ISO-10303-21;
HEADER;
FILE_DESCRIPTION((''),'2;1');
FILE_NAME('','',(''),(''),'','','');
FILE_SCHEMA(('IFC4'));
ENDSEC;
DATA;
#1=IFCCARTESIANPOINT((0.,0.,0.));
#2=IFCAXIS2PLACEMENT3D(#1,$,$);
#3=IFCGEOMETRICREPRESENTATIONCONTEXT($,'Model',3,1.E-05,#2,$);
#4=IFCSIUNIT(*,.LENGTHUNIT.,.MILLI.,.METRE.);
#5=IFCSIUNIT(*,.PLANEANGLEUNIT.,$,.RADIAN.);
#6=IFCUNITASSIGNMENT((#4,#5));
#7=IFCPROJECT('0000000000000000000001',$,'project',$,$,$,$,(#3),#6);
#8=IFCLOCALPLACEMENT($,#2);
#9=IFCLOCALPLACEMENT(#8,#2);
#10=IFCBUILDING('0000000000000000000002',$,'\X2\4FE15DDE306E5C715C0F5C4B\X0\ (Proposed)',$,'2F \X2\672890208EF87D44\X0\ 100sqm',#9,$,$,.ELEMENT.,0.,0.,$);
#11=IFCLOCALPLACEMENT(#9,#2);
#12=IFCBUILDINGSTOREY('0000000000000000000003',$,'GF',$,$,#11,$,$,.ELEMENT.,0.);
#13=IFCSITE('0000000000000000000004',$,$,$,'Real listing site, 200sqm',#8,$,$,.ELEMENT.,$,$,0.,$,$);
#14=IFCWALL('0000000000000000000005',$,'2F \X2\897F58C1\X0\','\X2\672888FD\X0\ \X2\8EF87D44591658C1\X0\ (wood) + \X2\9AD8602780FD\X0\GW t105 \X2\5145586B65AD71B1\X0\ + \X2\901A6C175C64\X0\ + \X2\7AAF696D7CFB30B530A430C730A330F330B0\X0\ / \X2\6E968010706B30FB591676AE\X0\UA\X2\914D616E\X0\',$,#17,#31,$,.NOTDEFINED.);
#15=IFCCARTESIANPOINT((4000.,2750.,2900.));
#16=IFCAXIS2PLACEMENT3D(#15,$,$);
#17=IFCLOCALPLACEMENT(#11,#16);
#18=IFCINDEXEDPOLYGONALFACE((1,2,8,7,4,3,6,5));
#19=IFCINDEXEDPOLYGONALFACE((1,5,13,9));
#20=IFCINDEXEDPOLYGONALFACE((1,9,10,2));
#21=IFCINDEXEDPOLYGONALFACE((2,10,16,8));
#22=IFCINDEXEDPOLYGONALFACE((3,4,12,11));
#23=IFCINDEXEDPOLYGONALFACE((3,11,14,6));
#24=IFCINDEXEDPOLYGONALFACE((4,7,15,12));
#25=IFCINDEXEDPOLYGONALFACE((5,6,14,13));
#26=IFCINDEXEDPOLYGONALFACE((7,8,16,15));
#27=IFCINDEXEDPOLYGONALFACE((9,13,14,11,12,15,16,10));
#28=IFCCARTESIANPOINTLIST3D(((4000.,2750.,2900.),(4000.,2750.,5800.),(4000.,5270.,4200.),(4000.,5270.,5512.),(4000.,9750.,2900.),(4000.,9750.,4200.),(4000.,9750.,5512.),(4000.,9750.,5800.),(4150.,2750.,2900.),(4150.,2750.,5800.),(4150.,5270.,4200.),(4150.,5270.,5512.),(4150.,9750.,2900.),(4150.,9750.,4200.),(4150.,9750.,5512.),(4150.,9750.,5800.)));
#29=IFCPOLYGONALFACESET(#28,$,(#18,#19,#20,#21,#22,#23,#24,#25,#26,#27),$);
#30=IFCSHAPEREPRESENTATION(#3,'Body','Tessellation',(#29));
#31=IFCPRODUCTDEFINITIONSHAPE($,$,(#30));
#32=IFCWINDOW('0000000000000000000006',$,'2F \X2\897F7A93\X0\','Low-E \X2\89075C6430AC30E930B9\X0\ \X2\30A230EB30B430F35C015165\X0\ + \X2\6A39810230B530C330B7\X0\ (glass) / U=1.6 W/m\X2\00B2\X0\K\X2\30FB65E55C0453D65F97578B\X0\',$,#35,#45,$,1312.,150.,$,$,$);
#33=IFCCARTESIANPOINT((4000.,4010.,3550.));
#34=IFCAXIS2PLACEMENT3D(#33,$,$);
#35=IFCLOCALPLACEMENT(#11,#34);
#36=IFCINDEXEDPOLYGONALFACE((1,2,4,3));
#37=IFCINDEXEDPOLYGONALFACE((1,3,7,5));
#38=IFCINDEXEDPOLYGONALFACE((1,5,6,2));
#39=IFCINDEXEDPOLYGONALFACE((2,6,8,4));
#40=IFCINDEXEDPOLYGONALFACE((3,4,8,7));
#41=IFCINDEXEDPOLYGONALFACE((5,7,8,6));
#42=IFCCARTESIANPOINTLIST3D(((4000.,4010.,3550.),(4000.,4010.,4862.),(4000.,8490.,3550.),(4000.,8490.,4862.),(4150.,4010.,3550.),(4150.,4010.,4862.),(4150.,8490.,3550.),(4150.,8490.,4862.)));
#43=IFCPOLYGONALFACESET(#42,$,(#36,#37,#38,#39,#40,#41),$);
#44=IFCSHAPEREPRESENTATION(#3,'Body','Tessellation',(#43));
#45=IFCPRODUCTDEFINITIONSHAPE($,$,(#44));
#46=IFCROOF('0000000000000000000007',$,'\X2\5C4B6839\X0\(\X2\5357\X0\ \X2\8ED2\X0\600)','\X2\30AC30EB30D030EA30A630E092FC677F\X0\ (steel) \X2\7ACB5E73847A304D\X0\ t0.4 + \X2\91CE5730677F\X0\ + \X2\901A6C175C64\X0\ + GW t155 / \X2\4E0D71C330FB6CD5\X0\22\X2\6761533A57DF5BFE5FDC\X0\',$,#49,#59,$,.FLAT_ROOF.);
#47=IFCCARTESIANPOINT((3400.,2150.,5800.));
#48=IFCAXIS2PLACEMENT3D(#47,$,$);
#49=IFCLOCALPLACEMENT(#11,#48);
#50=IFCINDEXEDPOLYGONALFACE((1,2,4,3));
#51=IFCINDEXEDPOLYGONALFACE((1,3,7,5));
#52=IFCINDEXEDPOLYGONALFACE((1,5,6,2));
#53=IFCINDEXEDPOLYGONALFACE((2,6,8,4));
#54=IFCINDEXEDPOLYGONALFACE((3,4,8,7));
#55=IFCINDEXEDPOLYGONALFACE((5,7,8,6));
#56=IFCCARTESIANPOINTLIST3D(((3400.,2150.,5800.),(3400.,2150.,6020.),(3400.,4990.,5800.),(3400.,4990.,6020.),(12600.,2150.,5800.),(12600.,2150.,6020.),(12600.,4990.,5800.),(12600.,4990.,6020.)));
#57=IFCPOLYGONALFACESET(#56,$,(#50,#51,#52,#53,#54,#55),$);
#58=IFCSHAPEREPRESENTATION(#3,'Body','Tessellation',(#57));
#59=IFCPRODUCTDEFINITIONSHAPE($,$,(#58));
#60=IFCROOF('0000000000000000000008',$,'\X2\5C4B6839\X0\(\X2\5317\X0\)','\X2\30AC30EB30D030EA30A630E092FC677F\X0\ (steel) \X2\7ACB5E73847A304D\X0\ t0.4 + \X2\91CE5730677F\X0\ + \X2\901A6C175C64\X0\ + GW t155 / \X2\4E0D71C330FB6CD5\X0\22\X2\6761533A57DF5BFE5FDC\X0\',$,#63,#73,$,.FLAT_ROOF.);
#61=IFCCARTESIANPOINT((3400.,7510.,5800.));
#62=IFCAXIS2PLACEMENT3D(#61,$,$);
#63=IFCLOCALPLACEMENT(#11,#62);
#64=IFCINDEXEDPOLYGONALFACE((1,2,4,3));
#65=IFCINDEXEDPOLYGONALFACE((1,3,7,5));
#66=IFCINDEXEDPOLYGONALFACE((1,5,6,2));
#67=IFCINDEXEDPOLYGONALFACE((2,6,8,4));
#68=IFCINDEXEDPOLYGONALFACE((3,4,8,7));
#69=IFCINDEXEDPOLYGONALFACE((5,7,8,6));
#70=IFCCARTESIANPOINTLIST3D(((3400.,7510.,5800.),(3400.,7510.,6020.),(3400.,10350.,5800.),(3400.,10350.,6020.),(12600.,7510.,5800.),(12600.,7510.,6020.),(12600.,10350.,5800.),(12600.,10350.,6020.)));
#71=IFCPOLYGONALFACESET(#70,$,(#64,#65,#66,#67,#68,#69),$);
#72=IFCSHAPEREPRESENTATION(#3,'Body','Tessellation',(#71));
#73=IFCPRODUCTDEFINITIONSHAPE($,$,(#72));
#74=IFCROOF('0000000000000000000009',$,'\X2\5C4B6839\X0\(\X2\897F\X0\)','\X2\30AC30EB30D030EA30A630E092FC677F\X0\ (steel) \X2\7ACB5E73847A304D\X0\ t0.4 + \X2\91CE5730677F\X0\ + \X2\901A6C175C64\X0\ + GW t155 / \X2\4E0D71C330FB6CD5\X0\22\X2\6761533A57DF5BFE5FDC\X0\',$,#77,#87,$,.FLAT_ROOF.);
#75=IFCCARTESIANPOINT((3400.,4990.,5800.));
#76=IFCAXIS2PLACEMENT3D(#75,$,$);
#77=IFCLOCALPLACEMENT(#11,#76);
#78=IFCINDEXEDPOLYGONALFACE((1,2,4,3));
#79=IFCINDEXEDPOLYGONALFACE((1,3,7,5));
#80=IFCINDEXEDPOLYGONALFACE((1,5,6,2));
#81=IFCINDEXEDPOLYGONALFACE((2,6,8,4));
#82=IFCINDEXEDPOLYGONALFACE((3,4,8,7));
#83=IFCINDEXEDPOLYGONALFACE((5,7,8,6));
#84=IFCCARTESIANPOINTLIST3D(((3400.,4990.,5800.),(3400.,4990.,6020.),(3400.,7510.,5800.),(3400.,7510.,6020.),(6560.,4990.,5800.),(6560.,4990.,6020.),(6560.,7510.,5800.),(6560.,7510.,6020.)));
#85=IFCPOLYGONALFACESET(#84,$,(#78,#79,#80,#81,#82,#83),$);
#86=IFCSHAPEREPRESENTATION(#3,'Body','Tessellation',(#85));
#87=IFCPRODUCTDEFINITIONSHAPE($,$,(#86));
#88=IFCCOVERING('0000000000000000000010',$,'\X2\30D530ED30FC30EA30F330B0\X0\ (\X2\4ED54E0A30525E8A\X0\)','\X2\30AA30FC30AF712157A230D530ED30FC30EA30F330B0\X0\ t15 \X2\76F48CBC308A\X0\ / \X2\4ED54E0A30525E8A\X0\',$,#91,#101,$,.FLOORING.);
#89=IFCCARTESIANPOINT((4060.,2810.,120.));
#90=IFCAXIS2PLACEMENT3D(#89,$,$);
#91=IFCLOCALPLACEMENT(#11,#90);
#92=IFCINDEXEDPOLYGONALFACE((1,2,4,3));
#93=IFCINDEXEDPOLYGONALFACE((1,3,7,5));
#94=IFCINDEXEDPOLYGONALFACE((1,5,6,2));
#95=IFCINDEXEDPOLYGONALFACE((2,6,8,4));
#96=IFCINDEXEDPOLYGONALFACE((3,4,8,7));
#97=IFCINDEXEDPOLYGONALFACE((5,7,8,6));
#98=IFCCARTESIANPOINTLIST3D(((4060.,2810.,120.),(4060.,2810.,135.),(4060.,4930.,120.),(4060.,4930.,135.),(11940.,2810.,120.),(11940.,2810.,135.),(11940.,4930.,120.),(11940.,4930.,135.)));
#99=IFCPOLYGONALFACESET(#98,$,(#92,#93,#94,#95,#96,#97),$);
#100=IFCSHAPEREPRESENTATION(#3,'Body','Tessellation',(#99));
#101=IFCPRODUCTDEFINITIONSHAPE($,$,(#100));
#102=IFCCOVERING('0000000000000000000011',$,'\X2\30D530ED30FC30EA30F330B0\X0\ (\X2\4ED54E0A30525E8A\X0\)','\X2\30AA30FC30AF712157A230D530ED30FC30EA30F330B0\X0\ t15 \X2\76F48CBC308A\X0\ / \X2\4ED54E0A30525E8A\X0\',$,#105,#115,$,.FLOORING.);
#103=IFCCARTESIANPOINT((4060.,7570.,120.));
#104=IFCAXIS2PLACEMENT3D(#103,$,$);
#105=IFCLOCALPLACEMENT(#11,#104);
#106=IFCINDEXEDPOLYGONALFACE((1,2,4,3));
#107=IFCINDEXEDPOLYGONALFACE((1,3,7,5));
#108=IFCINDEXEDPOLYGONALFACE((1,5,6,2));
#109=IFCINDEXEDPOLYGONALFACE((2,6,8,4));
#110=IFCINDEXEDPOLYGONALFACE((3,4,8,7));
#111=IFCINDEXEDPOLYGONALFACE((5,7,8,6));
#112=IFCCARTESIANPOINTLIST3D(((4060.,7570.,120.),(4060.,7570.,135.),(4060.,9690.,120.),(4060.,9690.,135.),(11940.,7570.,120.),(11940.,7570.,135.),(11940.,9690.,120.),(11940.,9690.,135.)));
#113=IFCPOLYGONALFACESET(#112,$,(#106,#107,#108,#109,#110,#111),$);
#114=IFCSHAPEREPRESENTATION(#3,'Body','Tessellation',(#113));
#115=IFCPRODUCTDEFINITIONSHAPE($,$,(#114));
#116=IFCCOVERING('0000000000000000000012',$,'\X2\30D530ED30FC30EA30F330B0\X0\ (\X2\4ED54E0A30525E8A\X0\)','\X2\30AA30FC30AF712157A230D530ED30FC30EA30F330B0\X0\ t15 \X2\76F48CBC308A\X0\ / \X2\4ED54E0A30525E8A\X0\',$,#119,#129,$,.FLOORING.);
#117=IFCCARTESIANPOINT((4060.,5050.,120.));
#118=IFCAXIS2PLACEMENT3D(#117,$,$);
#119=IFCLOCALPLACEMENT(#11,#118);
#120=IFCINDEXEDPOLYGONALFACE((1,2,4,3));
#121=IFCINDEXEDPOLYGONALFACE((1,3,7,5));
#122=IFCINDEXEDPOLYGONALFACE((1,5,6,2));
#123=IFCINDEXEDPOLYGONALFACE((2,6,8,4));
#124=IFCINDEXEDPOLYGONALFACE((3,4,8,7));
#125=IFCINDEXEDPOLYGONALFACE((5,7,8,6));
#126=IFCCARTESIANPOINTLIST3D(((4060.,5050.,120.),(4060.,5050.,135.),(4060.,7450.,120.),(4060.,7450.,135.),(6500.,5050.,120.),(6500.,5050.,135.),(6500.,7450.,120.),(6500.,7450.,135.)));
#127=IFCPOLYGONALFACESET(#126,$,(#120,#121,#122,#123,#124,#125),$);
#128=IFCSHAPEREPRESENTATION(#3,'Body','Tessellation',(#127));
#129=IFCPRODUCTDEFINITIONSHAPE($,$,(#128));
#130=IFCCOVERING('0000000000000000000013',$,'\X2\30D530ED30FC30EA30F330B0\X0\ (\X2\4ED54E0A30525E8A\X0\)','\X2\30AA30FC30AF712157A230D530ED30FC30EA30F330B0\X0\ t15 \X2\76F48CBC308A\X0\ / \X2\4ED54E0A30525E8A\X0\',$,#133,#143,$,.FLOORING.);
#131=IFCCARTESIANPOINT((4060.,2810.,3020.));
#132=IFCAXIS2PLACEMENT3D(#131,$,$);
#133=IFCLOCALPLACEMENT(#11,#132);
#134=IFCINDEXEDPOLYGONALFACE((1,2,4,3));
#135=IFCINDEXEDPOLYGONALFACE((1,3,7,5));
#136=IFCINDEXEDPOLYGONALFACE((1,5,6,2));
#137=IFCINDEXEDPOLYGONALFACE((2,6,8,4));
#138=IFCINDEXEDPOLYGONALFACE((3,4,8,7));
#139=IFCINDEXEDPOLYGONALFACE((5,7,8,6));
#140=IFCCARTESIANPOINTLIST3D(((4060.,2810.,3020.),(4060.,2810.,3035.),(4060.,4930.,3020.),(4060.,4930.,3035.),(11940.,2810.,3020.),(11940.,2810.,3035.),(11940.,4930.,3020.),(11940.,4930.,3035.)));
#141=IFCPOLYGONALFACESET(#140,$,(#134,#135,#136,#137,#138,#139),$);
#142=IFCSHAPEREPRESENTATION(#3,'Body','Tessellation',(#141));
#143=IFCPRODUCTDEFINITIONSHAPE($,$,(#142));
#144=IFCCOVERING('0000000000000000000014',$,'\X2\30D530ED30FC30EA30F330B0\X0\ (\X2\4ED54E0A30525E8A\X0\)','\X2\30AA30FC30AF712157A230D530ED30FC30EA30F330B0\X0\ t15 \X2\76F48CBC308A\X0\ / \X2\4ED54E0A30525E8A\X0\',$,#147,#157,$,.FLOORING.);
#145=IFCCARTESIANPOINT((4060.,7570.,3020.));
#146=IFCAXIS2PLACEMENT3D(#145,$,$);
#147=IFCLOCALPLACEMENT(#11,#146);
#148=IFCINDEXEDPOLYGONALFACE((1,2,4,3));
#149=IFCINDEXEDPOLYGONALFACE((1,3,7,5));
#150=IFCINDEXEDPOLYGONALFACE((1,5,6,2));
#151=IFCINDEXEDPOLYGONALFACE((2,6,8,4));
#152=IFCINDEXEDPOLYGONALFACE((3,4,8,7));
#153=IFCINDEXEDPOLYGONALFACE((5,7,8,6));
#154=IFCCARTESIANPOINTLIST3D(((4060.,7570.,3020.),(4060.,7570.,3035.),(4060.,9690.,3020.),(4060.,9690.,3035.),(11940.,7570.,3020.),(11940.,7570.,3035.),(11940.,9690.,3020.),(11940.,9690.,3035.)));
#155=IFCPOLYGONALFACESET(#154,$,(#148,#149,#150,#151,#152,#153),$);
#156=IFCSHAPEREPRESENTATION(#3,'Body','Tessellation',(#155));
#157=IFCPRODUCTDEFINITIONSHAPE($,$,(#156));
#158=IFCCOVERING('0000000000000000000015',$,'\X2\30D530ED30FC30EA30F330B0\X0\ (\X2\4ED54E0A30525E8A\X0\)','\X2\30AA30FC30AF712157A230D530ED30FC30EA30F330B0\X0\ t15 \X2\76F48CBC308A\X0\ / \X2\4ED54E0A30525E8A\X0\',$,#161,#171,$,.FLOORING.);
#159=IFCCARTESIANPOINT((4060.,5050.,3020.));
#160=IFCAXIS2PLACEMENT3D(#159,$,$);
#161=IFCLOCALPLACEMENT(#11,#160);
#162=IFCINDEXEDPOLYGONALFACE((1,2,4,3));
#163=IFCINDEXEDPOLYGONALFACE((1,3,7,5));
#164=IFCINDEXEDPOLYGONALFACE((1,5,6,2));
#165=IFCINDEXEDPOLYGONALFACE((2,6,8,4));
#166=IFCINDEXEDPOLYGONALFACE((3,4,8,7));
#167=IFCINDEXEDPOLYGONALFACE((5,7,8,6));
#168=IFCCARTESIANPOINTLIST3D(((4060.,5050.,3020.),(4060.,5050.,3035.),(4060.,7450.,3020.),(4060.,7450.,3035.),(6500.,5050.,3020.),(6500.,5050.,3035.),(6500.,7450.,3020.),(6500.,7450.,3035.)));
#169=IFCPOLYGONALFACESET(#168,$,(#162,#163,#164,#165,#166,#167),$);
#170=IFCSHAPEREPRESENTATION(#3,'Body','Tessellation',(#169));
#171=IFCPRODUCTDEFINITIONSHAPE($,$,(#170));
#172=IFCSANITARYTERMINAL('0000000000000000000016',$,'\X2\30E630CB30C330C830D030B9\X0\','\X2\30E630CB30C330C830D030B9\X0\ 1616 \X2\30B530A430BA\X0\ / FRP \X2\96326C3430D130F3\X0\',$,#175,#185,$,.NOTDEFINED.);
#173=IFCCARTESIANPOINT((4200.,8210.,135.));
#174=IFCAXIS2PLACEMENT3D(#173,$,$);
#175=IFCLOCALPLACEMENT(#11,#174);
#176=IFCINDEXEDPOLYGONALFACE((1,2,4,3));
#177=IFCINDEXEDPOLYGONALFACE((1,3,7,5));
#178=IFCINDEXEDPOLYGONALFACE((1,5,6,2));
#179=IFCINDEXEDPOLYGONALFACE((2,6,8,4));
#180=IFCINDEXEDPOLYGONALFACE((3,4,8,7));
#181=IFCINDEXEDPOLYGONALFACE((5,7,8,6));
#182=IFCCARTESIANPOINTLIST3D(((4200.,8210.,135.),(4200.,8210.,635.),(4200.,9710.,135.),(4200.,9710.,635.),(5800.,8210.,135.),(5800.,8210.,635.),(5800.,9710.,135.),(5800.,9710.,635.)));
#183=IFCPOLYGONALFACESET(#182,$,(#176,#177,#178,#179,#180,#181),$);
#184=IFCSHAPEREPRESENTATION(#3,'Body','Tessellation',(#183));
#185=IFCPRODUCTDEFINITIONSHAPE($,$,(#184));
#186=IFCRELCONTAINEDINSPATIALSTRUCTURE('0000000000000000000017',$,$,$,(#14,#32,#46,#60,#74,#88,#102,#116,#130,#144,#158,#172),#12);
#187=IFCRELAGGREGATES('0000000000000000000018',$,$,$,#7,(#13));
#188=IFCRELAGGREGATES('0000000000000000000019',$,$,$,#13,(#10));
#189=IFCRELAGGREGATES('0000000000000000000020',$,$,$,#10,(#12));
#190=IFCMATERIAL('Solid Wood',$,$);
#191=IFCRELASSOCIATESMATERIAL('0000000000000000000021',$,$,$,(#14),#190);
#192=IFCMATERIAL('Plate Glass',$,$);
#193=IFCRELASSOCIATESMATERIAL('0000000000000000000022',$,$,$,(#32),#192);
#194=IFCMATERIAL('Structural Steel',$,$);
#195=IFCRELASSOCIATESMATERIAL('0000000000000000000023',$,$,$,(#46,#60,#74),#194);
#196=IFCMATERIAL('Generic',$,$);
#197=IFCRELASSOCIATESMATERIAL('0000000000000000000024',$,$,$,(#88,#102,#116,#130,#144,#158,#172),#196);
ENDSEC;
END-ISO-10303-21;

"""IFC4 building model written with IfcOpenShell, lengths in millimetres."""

from ifc_helpers import new_model, si_unit, frame, frame_2d, origin, place, context, project, spatial, rectangle, extrude, material, element, fill, save


model = new_model("IFC4")

# Units and contexts
model_context = context("Model", 3, precision=1e-05, world=origin())
ifc_project = project(units=[si_unit("LENGTHUNIT", "METRE", prefix="MILLI"), si_unit("PLANEANGLEUNIT", "RADIAN")], contexts=[model_context])

# Site, building, storey
site_placement = place(None, origin())
site = spatial("IfcSite", under=ifc_project, at=site_placement, ObjectType="Real listing site, 200sqm", CompositionType="ELEMENT", RefElevation=0.0)
building_placement = place(site_placement, origin())
building = spatial("IfcBuilding", under=site, at=building_placement, Name="信州の山小屋 (Proposed)", ObjectType="2F 木造軸組 100sqm", CompositionType="ELEMENT", ElevationOfRefHeight=0.0, ElevationOfTerrain=0.0)
storey_placement = place(building_placement, origin())
storey = spatial("IfcBuildingStorey", under=building, at=storey_placement, Name="GF", CompositionType="ELEMENT", Elevation=0.0)

# Shared definitions
ifc_material_1 = material(Name="Solid Wood")

# Shared definitions
ifc_material_2 = material(Name="Plate Glass")

# Wall, opening, window
wall_1_placement = place(storey_placement, frame((4000.0, 2750.0, 2900.0)))
wall_1 = element("IfcWall", 1, at=wall_1_placement, inside=storey, material=ifc_material_1, Name="2F 西壁", Description="木製 軸組外壁 (wood) + 高性能GW t105 充填断熱 + 通気層 + 窯業系サイディング / 準耐火・外皮UA配慮", PredefinedType="NOTDEFINED", context=model_context, shape_type="SweptSolid", body=[
    extrude(rectangle(XDim=150.0, YDim=7000.0, at=frame_2d((75.0, 3500.0))), frame((4000.0, 2750.0, 2900.0)), (0.0, 0.0, 1.0), 2900.0),
])
opening_1_placement = place(storey_placement, frame((4000.0, 4010.0, 3550.0)))
opening_1 = element("IfcOpeningElement", 2, at=opening_1_placement, cuts=wall_1, PredefinedType="NOTDEFINED", context=model_context, shape_type="SweptSolid", body=[
    extrude(rectangle(XDim=150.0, YDim=4480.0, at=frame_2d((75.0, 2240.0))), frame((4000.0, 4010.0, 3550.0)), (0.0, 0.0, 1.0), 1312.0),
])
window_1_placement = place(storey_placement, frame((4000.0, 4010.0, 3550.0)))
window_1 = element("IfcWindow", 3, at=window_1_placement, inside=storey, material=ifc_material_2, Name="2F 西窓", Description="Low-E 複層ガラス アルゴン封入 + 樹脂サッシ (glass) / U=1.6 W/m²K・日射取得型", OverallHeight=1312.0, OverallWidth=150.0, context=model_context, shape_type="SweptSolid", body=[
    extrude(rectangle(XDim=150.0, YDim=4480.0, at=frame_2d((75.0, 2240.0))), frame((4000.0, 4010.0, 3550.0)), (0.0, 0.0, 1.0), 1312.0),
])
fill(opening_1, window_1)

# Roofs
ifc_material_3 = material(Name="Structural Steel")
roof_1_placement = place(storey_placement, frame((3400.0, 2150.0, 5800.0)))
element("IfcRoof", 4, at=roof_1_placement, inside=storey, material=ifc_material_3, Name="屋根(南 軒600)", Description="ガルバリウム鋼板 (steel) 立平葺き t0.4 + 野地板 + 通気層 + GW t155 / 不燃・法22条区域対応", PredefinedType="FLAT_ROOF", context=model_context, shape_type="SweptSolid", body=[
    extrude(rectangle(XDim=9200.0, YDim=2840.0, at=frame_2d((4600.0, 1420.0))), frame((3400.0, 2150.0, 5800.0)), (0.0, 0.0, 1.0), 220.0),
])
roof_2_placement = place(storey_placement, frame((3400.0, 7510.0, 5800.0)))
element("IfcRoof", 5, at=roof_2_placement, inside=storey, material=ifc_material_3, Name="屋根(北)", Description="ガルバリウム鋼板 (steel) 立平葺き t0.4 + 野地板 + 通気層 + GW t155 / 不燃・法22条区域対応", PredefinedType="FLAT_ROOF", context=model_context, shape_type="SweptSolid", body=[
    extrude(rectangle(XDim=9200.0, YDim=2840.0, at=frame_2d((4600.0, 1420.0))), frame((3400.0, 7510.0, 5800.0)), (0.0, 0.0, 1.0), 220.0),
])
roof_3_placement = place(storey_placement, frame((3400.0, 4990.0, 5800.0)))
element("IfcRoof", 6, at=roof_3_placement, inside=storey, material=ifc_material_3, Name="屋根(西)", Description="ガルバリウム鋼板 (steel) 立平葺き t0.4 + 野地板 + 通気層 + GW t155 / 不燃・法22条区域対応", PredefinedType="FLAT_ROOF", context=model_context, shape_type="SweptSolid", body=[
    extrude(rectangle(XDim=3160.0, YDim=2520.0, at=frame_2d((1580.0, 1260.0))), frame((3400.0, 4990.0, 5800.0)), (0.0, 0.0, 1.0), 220.0),
])

# Coverings
ifc_material_4 = material(Name="Generic")
covering_1_placement = place(storey_placement, frame((4060.0, 2810.0, 120.0)))
element("IfcCovering", 7, at=covering_1_placement, inside=storey, material=ifc_material_4, Name="フローリング (仕上げ床)", Description="オーク無垢フローリング t15 直貼り / 仕上げ床", PredefinedType="FLOORING", context=model_context, shape_type="SweptSolid", body=[
    extrude(rectangle(XDim=7880.0, YDim=2120.0, at=frame_2d((3940.0, 1060.0))), frame((4060.0, 2810.0, 120.0)), (0.0, 0.0, 1.0), 15.0),
])
covering_2_placement = place(storey_placement, frame((4060.0, 7570.0, 120.0)))
element("IfcCovering", 8, at=covering_2_placement, inside=storey, material=ifc_material_4, Name="フローリング (仕上げ床)", Description="オーク無垢フローリング t15 直貼り / 仕上げ床", PredefinedType="FLOORING", context=model_context, shape_type="SweptSolid", body=[
    extrude(rectangle(XDim=7880.0, YDim=2120.0, at=frame_2d((3940.0, 1060.0))), frame((4060.0, 7570.0, 120.0)), (0.0, 0.0, 1.0), 15.0),
])
covering_3_placement = place(storey_placement, frame((4060.0, 5050.0, 120.0)))
element("IfcCovering", 9, at=covering_3_placement, inside=storey, material=ifc_material_4, Name="フローリング (仕上げ床)", Description="オーク無垢フローリング t15 直貼り / 仕上げ床", PredefinedType="FLOORING", context=model_context, shape_type="SweptSolid", body=[
    extrude(rectangle(XDim=2440.0, YDim=2400.0, at=frame_2d((1220.0, 1200.0))), frame((4060.0, 5050.0, 120.0)), (0.0, 0.0, 1.0), 15.0),
])
covering_4_placement = place(storey_placement, frame((4060.0, 2810.0, 3020.0)))
element("IfcCovering", 10, at=covering_4_placement, inside=storey, material=ifc_material_4, Name="フローリング (仕上げ床)", Description="オーク無垢フローリング t15 直貼り / 仕上げ床", PredefinedType="FLOORING", context=model_context, shape_type="SweptSolid", body=[
    extrude(rectangle(XDim=7880.0, YDim=2120.0, at=frame_2d((3940.0, 1060.0))), frame((4060.0, 2810.0, 3020.0)), (0.0, 0.0, 1.0), 15.0),
])
covering_5_placement = place(storey_placement, frame((4060.0, 7570.0, 3020.0)))
element("IfcCovering", 11, at=covering_5_placement, inside=storey, material=ifc_material_4, Name="フローリング (仕上げ床)", Description="オーク無垢フローリング t15 直貼り / 仕上げ床", PredefinedType="FLOORING", context=model_context, shape_type="SweptSolid", body=[
    extrude(rectangle(XDim=7880.0, YDim=2120.0, at=frame_2d((3940.0, 1060.0))), frame((4060.0, 7570.0, 3020.0)), (0.0, 0.0, 1.0), 15.0),
])
covering_6_placement = place(storey_placement, frame((4060.0, 5050.0, 3020.0)))
element("IfcCovering", 12, at=covering_6_placement, inside=storey, material=ifc_material_4, Name="フローリング (仕上げ床)", Description="オーク無垢フローリング t15 直貼り / 仕上げ床", PredefinedType="FLOORING", context=model_context, shape_type="SweptSolid", body=[
    extrude(rectangle(XDim=2440.0, YDim=2400.0, at=frame_2d((1220.0, 1200.0))), frame((4060.0, 5050.0, 3020.0)), (0.0, 0.0, 1.0), 15.0),
])

# Sanitary terminal
sanitary_terminal_placement = place(storey_placement, frame((4200.0, 8210.0, 135.0)))
element("IfcSanitaryTerminal", 13, at=sanitary_terminal_placement, inside=storey, material=ifc_material_4, Name="ユニットバス", Description="ユニットバス 1616 サイズ / FRP 防水パン", PredefinedType="NOTDEFINED", context=model_context, shape_type="SweptSolid", body=[
    extrude(rectangle(XDim=1600.0, YDim=1500.0, at=frame_2d((800.0, 750.0))), frame((4200.0, 8210.0, 135.0)), (0.0, 0.0, 1.0), 500.0),
])

save(model, "model.ifc")
